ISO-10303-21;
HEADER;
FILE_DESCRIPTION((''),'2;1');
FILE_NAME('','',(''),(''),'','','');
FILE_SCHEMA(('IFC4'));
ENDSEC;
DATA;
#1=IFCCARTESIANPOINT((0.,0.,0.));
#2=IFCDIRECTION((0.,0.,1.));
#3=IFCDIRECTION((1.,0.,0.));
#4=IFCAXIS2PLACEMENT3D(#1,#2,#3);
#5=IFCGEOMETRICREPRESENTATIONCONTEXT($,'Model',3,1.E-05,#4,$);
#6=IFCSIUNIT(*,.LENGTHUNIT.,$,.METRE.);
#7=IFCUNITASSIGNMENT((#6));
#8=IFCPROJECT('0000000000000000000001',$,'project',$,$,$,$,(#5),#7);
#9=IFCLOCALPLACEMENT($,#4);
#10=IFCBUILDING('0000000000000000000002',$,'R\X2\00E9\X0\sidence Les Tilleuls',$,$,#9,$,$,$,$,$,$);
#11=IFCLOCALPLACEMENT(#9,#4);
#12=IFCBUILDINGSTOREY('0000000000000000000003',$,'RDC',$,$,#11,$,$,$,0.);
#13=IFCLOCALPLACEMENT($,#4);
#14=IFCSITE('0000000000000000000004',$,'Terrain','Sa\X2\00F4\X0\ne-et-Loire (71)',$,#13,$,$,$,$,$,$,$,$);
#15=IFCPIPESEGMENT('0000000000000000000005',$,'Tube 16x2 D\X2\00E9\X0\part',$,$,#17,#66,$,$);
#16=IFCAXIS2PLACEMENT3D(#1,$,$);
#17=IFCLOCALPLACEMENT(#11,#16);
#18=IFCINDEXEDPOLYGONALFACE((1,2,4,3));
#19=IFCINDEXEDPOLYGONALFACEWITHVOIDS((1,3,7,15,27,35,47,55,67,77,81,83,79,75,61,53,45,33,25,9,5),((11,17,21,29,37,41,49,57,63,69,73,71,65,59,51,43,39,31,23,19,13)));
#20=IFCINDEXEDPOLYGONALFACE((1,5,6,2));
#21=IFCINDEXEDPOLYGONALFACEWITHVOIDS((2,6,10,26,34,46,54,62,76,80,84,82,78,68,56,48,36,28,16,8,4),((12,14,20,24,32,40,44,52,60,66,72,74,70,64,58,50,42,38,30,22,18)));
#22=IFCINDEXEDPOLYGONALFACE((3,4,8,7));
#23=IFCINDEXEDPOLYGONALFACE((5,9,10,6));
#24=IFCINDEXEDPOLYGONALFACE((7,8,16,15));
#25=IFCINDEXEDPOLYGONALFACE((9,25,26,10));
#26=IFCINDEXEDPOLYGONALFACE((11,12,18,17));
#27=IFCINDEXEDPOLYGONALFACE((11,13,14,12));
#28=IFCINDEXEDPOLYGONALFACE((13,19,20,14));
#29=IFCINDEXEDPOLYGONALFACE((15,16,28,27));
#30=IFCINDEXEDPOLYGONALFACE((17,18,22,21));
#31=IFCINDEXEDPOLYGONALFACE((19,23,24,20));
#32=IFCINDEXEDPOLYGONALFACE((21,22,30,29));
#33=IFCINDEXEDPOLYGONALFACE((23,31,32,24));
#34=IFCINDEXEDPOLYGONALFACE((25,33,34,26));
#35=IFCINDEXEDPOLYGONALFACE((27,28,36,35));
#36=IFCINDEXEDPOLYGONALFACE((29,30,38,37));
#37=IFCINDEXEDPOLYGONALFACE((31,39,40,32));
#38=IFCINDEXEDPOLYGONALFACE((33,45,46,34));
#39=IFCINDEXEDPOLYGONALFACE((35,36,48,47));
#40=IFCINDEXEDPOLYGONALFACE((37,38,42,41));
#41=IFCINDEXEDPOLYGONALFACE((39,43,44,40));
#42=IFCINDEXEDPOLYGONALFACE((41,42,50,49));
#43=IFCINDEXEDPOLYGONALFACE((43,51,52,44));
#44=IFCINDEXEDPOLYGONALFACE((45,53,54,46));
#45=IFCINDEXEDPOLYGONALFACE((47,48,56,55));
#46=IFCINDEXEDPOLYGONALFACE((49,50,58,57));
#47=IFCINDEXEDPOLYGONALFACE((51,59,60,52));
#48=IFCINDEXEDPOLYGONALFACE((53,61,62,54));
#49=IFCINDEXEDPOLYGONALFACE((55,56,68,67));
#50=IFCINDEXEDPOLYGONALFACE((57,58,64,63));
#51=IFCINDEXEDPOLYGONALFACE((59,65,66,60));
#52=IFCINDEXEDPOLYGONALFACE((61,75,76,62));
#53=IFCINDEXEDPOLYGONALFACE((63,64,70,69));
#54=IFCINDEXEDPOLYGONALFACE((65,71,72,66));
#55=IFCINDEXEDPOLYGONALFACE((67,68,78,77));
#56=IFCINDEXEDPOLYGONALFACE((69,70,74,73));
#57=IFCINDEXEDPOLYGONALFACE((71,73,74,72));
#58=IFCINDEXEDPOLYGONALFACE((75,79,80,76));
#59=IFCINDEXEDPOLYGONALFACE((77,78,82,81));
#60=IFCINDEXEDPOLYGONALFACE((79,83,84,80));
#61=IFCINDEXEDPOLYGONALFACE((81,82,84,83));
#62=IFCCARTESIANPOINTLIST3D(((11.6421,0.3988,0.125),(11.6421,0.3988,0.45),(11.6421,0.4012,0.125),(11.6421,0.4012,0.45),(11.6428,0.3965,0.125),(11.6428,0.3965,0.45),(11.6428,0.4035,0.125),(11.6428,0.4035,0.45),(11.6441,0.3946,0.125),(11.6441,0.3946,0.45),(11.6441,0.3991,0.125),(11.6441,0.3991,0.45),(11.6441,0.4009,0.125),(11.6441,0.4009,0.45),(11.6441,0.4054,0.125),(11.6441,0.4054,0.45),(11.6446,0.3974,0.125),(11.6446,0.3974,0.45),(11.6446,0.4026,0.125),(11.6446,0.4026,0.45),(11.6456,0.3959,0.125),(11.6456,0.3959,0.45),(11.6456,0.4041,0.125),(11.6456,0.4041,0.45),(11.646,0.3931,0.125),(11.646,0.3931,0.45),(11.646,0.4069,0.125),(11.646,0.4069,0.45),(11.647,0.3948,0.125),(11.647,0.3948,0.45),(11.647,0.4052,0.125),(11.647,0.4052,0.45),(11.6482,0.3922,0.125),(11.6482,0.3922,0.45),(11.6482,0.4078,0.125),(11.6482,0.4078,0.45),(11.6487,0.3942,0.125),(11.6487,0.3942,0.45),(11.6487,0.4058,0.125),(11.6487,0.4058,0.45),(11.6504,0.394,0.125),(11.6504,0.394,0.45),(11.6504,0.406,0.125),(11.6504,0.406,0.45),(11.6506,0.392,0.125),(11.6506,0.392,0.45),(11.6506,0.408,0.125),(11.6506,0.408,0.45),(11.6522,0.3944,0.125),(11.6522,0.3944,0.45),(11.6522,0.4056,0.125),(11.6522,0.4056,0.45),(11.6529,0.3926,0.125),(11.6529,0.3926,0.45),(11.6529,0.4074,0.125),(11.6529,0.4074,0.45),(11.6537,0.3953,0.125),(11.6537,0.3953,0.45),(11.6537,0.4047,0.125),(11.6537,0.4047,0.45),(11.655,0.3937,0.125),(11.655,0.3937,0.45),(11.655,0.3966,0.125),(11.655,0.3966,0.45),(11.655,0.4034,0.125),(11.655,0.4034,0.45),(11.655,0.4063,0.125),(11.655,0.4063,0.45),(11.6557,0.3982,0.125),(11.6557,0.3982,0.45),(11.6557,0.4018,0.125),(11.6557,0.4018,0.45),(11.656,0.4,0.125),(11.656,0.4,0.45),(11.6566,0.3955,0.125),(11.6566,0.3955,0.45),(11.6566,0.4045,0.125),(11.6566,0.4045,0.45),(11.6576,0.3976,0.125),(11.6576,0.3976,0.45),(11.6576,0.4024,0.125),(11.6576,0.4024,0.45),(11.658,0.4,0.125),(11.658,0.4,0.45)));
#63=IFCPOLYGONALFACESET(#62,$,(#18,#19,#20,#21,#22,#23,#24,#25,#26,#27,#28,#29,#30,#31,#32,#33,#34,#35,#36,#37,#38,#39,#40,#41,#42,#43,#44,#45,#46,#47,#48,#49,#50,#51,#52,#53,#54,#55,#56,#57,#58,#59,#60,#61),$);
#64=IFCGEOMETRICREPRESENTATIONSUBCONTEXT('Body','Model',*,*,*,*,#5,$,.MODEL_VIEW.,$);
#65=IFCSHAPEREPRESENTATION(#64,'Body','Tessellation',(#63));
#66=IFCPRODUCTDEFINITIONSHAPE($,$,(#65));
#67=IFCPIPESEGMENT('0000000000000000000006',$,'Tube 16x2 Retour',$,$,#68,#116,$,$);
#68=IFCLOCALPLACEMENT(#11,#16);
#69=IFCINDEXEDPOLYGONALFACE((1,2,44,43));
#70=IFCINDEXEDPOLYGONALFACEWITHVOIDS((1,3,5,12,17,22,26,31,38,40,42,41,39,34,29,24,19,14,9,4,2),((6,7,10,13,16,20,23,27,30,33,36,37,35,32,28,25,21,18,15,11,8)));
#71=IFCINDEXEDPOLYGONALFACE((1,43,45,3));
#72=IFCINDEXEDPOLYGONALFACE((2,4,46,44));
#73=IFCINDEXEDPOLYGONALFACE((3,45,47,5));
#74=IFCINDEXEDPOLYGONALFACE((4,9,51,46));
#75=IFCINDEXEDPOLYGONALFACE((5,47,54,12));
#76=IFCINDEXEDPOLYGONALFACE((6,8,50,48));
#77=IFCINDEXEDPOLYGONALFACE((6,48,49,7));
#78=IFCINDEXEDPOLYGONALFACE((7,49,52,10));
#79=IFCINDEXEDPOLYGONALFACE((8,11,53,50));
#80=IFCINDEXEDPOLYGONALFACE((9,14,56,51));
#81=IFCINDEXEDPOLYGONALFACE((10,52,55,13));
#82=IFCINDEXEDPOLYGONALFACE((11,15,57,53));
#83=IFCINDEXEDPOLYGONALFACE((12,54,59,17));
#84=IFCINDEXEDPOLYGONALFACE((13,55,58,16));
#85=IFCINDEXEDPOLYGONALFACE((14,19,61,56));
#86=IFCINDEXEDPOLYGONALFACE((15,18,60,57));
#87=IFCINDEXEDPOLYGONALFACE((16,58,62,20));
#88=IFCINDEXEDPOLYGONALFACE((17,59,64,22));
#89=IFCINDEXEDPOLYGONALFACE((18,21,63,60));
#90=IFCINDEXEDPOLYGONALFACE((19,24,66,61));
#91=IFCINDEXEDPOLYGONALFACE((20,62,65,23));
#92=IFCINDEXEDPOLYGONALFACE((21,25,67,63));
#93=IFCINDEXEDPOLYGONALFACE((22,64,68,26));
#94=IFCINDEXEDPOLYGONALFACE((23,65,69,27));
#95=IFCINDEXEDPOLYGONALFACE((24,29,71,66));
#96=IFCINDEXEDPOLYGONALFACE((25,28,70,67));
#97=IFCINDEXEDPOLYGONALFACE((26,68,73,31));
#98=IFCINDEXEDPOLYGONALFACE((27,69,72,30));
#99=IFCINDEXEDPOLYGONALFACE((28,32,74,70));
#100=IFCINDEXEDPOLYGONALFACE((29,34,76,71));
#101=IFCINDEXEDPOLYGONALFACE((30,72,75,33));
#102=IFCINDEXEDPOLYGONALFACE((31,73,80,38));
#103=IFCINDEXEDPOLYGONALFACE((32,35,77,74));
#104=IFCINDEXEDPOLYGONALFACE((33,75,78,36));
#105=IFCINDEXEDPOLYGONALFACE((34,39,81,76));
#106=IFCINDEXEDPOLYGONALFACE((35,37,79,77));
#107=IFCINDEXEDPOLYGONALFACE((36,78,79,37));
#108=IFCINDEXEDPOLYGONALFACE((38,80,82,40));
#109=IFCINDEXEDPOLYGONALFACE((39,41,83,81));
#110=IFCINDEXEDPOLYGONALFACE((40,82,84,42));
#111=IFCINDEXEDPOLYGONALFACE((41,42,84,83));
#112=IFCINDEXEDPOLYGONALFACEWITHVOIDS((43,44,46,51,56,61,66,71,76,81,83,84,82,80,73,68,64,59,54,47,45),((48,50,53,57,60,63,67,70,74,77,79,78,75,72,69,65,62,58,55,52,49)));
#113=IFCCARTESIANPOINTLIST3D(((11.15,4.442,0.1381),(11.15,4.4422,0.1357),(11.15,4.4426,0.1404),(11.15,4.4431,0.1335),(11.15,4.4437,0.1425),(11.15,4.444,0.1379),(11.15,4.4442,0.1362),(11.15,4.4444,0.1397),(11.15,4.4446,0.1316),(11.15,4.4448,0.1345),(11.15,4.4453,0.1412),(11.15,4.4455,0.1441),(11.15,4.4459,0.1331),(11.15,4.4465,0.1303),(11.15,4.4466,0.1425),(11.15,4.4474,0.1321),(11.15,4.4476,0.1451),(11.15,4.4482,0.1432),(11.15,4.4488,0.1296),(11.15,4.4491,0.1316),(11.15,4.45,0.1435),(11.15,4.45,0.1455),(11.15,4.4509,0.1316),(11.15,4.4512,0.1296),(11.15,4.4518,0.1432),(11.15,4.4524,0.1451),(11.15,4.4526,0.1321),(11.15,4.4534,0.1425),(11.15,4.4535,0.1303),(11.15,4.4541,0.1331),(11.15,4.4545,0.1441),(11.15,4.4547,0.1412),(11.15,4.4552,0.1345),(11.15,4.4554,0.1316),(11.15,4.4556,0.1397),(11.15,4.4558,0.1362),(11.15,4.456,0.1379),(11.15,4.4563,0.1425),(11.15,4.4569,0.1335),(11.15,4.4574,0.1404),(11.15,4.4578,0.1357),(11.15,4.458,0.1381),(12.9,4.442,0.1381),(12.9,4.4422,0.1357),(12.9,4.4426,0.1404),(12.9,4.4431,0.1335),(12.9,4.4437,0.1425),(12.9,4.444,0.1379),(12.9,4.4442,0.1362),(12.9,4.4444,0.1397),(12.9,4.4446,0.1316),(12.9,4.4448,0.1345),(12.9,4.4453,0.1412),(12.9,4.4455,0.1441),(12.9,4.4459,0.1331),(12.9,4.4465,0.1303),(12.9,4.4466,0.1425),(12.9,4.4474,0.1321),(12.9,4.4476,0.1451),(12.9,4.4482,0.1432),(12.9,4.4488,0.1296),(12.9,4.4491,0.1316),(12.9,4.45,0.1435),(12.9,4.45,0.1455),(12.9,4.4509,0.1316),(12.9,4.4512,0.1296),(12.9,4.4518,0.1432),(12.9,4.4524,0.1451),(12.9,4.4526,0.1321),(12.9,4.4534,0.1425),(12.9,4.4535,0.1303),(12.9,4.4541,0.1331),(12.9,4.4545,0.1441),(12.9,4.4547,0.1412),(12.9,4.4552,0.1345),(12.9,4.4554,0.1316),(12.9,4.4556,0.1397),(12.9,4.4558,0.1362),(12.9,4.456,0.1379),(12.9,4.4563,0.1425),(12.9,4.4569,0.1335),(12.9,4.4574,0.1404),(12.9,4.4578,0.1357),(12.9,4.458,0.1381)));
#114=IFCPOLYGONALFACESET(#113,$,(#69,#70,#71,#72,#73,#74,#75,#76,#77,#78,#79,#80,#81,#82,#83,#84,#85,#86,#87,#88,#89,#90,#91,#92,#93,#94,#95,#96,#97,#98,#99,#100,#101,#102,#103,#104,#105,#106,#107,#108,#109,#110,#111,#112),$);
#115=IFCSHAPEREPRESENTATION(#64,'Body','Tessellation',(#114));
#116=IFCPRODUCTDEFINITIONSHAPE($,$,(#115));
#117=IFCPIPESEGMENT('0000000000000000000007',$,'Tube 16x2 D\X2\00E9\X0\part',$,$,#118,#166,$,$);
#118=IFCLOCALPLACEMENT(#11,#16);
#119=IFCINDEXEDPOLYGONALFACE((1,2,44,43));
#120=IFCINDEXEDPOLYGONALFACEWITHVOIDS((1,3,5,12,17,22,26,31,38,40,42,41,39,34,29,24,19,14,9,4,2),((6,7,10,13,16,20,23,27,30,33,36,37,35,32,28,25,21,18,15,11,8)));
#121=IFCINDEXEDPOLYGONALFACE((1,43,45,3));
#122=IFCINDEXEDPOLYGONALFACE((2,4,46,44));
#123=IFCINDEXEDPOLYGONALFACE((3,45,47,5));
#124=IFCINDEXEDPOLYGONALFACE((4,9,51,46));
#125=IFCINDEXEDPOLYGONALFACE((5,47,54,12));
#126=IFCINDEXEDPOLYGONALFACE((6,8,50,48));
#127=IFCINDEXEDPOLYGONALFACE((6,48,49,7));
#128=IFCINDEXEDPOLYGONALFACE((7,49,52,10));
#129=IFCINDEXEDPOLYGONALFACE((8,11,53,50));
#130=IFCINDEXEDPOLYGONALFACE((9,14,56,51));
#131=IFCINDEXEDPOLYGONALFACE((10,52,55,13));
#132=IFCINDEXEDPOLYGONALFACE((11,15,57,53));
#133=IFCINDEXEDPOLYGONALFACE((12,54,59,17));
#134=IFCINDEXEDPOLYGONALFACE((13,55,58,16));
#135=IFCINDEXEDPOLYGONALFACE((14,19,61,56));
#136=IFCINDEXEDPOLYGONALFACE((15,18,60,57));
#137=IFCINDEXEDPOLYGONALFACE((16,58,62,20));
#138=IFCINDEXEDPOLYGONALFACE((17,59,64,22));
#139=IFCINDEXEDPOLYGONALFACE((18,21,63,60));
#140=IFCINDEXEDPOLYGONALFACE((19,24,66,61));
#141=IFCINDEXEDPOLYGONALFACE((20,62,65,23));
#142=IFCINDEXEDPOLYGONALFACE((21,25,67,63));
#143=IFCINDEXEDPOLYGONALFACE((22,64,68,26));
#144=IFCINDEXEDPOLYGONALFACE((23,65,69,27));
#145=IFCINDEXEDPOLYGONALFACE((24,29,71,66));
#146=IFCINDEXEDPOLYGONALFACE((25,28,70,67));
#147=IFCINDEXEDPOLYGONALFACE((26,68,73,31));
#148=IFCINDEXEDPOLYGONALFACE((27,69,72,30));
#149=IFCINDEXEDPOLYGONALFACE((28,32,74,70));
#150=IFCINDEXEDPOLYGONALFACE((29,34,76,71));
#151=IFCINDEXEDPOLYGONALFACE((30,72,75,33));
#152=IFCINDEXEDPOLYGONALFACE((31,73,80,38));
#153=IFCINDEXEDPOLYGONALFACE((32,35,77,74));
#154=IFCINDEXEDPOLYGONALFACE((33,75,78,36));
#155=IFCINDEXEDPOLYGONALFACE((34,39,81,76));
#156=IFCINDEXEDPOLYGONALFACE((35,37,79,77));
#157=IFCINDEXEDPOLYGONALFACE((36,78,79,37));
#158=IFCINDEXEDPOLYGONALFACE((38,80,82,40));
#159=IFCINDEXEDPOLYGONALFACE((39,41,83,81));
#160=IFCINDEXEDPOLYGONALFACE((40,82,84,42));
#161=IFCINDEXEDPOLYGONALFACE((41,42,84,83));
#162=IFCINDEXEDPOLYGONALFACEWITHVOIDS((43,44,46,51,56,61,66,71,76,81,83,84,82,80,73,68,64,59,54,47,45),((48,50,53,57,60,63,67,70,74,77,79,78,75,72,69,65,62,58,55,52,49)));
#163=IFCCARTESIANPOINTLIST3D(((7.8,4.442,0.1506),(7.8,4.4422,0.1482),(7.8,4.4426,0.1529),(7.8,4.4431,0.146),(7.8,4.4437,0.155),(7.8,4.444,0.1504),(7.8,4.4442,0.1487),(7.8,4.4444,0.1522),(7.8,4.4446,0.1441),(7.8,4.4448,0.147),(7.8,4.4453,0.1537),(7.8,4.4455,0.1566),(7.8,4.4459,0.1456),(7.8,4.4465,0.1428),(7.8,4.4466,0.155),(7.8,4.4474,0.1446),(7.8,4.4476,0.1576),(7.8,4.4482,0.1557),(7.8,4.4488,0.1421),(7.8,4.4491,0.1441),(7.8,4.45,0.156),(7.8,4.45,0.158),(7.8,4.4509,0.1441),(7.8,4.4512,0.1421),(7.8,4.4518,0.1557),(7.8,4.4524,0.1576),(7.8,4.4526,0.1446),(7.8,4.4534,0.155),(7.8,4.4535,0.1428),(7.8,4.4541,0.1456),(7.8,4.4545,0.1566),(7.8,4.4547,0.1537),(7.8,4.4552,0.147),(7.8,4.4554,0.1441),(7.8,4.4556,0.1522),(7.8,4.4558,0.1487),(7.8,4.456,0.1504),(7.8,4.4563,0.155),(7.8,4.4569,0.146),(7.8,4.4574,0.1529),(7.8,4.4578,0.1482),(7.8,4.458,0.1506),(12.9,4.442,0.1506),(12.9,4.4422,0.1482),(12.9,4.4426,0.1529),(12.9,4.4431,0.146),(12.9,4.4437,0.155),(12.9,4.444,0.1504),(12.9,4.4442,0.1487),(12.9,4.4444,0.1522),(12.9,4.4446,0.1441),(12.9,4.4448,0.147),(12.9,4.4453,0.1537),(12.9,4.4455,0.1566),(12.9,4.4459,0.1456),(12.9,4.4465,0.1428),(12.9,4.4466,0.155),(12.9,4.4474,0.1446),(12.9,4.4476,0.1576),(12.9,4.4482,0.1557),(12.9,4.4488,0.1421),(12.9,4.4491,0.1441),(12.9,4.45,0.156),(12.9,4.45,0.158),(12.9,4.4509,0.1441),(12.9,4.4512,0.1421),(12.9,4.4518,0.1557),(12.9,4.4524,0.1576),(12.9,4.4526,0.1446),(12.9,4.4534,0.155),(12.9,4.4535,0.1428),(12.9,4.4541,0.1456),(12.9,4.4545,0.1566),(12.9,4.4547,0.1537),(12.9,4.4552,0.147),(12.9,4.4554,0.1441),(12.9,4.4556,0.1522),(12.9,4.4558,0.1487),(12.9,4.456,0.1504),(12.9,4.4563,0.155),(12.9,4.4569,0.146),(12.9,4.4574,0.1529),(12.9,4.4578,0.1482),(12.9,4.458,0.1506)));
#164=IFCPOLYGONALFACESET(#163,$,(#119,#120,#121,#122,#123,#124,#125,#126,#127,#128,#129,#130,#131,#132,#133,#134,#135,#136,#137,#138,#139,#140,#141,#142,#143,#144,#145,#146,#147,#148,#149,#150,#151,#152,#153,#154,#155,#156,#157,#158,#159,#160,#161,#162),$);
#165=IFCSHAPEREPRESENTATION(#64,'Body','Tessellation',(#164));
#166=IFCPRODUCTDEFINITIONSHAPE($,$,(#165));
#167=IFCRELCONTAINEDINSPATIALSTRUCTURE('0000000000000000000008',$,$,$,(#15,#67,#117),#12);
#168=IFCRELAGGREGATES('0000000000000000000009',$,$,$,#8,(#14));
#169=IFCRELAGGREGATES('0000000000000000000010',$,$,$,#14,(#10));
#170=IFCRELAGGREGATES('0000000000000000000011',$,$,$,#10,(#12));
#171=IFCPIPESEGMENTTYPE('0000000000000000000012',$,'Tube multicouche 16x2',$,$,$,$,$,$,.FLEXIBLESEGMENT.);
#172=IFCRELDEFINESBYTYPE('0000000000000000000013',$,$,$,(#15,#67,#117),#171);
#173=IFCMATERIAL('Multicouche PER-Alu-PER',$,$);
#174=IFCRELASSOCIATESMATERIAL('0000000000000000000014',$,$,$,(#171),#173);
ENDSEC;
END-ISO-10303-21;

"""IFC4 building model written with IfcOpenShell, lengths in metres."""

from ifc_helpers import new_model, si_unit, frame, origin_with_axes, place, context, subcontext, project, spatial, hollow_circle, extrude, material, type_object, element, save


model = new_model("IFC4")

# Units and contexts
model_context = context("Model", 3, precision=1e-05, world=origin_with_axes())
body_context = subcontext(model_context, "Body", "Model", "MODEL_VIEW")
ifc_project = project(units=[si_unit("LENGTHUNIT", "METRE")], contexts=[model_context])

# Site, building, storey
site_placement = place(None, origin_with_axes())
site = spatial("IfcSite", under=ifc_project, at=site_placement, Name="Terrain", Description="Saône-et-Loire (71)")
building_placement = place(None, origin_with_axes())
building = spatial("IfcBuilding", under=site, at=building_placement, Name="Résidence Les Tilleuls")
storey_placement = place(building_placement, origin_with_axes())
storey = spatial("IfcBuildingStorey", under=building, at=storey_placement, Name="RDC", Elevation=0.0)

# Pipe segments
ifc_material = material(Name="Multicouche PER-Alu-PER")
pipe_segment_type_1 = type_object("IfcPipeSegmentType", Name="Tube multicouche 16x2", PredefinedType="FLEXIBLESEGMENT", material=ifc_material)
pipe_segment_1_placement = place(storey_placement, frame((11.65, 0.4, 0.125), z_axis=(0.0, 0.0, 1.0), x_axis=(1.0, 0.0, 0.0)))
element("IfcPipeSegment", 1, at=pipe_segment_1_placement, inside=storey, type_object=pipe_segment_type_1, Name="Tube 16x2 Départ", context=body_context, shape_type="SweptSolid", body=[
    extrude(hollow_circle(Radius=0.008, WallThickness=0.002), origin_with_axes(), (0.0, 0.0, 1.0), 0.325),
])
pipe_segment_2_placement = place(storey_placement, frame((12.9, 4.45, 0.1375), z_axis=(-1.0, 0.0, 0.0), x_axis=(0.0, 0.0, 1.0)))
element("IfcPipeSegment", 2, at=pipe_segment_2_placement, inside=storey, type_object=pipe_segment_type_1, Name="Tube 16x2 Retour", context=body_context, shape_type="SweptSolid", body=[
    extrude(hollow_circle(Radius=0.008, WallThickness=0.002), origin_with_axes(), (0.0, 0.0, 1.0), 1.75),
])
pipe_segment_3_placement = place(storey_placement, frame((12.9, 4.45, 0.15), z_axis=(-1.0, 0.0, 0.0), x_axis=(0.0, 0.0, 1.0)))
element("IfcPipeSegment", 3, at=pipe_segment_3_placement, inside=storey, type_object=pipe_segment_type_1, Name="Tube 16x2 Départ", context=body_context, shape_type="SweptSolid", body=[
    extrude(hollow_circle(Radius=0.008, WallThickness=0.002), origin_with_axes(), (0.0, 0.0, 1.0), 5.1),
])

save(model, "model.ifc")
